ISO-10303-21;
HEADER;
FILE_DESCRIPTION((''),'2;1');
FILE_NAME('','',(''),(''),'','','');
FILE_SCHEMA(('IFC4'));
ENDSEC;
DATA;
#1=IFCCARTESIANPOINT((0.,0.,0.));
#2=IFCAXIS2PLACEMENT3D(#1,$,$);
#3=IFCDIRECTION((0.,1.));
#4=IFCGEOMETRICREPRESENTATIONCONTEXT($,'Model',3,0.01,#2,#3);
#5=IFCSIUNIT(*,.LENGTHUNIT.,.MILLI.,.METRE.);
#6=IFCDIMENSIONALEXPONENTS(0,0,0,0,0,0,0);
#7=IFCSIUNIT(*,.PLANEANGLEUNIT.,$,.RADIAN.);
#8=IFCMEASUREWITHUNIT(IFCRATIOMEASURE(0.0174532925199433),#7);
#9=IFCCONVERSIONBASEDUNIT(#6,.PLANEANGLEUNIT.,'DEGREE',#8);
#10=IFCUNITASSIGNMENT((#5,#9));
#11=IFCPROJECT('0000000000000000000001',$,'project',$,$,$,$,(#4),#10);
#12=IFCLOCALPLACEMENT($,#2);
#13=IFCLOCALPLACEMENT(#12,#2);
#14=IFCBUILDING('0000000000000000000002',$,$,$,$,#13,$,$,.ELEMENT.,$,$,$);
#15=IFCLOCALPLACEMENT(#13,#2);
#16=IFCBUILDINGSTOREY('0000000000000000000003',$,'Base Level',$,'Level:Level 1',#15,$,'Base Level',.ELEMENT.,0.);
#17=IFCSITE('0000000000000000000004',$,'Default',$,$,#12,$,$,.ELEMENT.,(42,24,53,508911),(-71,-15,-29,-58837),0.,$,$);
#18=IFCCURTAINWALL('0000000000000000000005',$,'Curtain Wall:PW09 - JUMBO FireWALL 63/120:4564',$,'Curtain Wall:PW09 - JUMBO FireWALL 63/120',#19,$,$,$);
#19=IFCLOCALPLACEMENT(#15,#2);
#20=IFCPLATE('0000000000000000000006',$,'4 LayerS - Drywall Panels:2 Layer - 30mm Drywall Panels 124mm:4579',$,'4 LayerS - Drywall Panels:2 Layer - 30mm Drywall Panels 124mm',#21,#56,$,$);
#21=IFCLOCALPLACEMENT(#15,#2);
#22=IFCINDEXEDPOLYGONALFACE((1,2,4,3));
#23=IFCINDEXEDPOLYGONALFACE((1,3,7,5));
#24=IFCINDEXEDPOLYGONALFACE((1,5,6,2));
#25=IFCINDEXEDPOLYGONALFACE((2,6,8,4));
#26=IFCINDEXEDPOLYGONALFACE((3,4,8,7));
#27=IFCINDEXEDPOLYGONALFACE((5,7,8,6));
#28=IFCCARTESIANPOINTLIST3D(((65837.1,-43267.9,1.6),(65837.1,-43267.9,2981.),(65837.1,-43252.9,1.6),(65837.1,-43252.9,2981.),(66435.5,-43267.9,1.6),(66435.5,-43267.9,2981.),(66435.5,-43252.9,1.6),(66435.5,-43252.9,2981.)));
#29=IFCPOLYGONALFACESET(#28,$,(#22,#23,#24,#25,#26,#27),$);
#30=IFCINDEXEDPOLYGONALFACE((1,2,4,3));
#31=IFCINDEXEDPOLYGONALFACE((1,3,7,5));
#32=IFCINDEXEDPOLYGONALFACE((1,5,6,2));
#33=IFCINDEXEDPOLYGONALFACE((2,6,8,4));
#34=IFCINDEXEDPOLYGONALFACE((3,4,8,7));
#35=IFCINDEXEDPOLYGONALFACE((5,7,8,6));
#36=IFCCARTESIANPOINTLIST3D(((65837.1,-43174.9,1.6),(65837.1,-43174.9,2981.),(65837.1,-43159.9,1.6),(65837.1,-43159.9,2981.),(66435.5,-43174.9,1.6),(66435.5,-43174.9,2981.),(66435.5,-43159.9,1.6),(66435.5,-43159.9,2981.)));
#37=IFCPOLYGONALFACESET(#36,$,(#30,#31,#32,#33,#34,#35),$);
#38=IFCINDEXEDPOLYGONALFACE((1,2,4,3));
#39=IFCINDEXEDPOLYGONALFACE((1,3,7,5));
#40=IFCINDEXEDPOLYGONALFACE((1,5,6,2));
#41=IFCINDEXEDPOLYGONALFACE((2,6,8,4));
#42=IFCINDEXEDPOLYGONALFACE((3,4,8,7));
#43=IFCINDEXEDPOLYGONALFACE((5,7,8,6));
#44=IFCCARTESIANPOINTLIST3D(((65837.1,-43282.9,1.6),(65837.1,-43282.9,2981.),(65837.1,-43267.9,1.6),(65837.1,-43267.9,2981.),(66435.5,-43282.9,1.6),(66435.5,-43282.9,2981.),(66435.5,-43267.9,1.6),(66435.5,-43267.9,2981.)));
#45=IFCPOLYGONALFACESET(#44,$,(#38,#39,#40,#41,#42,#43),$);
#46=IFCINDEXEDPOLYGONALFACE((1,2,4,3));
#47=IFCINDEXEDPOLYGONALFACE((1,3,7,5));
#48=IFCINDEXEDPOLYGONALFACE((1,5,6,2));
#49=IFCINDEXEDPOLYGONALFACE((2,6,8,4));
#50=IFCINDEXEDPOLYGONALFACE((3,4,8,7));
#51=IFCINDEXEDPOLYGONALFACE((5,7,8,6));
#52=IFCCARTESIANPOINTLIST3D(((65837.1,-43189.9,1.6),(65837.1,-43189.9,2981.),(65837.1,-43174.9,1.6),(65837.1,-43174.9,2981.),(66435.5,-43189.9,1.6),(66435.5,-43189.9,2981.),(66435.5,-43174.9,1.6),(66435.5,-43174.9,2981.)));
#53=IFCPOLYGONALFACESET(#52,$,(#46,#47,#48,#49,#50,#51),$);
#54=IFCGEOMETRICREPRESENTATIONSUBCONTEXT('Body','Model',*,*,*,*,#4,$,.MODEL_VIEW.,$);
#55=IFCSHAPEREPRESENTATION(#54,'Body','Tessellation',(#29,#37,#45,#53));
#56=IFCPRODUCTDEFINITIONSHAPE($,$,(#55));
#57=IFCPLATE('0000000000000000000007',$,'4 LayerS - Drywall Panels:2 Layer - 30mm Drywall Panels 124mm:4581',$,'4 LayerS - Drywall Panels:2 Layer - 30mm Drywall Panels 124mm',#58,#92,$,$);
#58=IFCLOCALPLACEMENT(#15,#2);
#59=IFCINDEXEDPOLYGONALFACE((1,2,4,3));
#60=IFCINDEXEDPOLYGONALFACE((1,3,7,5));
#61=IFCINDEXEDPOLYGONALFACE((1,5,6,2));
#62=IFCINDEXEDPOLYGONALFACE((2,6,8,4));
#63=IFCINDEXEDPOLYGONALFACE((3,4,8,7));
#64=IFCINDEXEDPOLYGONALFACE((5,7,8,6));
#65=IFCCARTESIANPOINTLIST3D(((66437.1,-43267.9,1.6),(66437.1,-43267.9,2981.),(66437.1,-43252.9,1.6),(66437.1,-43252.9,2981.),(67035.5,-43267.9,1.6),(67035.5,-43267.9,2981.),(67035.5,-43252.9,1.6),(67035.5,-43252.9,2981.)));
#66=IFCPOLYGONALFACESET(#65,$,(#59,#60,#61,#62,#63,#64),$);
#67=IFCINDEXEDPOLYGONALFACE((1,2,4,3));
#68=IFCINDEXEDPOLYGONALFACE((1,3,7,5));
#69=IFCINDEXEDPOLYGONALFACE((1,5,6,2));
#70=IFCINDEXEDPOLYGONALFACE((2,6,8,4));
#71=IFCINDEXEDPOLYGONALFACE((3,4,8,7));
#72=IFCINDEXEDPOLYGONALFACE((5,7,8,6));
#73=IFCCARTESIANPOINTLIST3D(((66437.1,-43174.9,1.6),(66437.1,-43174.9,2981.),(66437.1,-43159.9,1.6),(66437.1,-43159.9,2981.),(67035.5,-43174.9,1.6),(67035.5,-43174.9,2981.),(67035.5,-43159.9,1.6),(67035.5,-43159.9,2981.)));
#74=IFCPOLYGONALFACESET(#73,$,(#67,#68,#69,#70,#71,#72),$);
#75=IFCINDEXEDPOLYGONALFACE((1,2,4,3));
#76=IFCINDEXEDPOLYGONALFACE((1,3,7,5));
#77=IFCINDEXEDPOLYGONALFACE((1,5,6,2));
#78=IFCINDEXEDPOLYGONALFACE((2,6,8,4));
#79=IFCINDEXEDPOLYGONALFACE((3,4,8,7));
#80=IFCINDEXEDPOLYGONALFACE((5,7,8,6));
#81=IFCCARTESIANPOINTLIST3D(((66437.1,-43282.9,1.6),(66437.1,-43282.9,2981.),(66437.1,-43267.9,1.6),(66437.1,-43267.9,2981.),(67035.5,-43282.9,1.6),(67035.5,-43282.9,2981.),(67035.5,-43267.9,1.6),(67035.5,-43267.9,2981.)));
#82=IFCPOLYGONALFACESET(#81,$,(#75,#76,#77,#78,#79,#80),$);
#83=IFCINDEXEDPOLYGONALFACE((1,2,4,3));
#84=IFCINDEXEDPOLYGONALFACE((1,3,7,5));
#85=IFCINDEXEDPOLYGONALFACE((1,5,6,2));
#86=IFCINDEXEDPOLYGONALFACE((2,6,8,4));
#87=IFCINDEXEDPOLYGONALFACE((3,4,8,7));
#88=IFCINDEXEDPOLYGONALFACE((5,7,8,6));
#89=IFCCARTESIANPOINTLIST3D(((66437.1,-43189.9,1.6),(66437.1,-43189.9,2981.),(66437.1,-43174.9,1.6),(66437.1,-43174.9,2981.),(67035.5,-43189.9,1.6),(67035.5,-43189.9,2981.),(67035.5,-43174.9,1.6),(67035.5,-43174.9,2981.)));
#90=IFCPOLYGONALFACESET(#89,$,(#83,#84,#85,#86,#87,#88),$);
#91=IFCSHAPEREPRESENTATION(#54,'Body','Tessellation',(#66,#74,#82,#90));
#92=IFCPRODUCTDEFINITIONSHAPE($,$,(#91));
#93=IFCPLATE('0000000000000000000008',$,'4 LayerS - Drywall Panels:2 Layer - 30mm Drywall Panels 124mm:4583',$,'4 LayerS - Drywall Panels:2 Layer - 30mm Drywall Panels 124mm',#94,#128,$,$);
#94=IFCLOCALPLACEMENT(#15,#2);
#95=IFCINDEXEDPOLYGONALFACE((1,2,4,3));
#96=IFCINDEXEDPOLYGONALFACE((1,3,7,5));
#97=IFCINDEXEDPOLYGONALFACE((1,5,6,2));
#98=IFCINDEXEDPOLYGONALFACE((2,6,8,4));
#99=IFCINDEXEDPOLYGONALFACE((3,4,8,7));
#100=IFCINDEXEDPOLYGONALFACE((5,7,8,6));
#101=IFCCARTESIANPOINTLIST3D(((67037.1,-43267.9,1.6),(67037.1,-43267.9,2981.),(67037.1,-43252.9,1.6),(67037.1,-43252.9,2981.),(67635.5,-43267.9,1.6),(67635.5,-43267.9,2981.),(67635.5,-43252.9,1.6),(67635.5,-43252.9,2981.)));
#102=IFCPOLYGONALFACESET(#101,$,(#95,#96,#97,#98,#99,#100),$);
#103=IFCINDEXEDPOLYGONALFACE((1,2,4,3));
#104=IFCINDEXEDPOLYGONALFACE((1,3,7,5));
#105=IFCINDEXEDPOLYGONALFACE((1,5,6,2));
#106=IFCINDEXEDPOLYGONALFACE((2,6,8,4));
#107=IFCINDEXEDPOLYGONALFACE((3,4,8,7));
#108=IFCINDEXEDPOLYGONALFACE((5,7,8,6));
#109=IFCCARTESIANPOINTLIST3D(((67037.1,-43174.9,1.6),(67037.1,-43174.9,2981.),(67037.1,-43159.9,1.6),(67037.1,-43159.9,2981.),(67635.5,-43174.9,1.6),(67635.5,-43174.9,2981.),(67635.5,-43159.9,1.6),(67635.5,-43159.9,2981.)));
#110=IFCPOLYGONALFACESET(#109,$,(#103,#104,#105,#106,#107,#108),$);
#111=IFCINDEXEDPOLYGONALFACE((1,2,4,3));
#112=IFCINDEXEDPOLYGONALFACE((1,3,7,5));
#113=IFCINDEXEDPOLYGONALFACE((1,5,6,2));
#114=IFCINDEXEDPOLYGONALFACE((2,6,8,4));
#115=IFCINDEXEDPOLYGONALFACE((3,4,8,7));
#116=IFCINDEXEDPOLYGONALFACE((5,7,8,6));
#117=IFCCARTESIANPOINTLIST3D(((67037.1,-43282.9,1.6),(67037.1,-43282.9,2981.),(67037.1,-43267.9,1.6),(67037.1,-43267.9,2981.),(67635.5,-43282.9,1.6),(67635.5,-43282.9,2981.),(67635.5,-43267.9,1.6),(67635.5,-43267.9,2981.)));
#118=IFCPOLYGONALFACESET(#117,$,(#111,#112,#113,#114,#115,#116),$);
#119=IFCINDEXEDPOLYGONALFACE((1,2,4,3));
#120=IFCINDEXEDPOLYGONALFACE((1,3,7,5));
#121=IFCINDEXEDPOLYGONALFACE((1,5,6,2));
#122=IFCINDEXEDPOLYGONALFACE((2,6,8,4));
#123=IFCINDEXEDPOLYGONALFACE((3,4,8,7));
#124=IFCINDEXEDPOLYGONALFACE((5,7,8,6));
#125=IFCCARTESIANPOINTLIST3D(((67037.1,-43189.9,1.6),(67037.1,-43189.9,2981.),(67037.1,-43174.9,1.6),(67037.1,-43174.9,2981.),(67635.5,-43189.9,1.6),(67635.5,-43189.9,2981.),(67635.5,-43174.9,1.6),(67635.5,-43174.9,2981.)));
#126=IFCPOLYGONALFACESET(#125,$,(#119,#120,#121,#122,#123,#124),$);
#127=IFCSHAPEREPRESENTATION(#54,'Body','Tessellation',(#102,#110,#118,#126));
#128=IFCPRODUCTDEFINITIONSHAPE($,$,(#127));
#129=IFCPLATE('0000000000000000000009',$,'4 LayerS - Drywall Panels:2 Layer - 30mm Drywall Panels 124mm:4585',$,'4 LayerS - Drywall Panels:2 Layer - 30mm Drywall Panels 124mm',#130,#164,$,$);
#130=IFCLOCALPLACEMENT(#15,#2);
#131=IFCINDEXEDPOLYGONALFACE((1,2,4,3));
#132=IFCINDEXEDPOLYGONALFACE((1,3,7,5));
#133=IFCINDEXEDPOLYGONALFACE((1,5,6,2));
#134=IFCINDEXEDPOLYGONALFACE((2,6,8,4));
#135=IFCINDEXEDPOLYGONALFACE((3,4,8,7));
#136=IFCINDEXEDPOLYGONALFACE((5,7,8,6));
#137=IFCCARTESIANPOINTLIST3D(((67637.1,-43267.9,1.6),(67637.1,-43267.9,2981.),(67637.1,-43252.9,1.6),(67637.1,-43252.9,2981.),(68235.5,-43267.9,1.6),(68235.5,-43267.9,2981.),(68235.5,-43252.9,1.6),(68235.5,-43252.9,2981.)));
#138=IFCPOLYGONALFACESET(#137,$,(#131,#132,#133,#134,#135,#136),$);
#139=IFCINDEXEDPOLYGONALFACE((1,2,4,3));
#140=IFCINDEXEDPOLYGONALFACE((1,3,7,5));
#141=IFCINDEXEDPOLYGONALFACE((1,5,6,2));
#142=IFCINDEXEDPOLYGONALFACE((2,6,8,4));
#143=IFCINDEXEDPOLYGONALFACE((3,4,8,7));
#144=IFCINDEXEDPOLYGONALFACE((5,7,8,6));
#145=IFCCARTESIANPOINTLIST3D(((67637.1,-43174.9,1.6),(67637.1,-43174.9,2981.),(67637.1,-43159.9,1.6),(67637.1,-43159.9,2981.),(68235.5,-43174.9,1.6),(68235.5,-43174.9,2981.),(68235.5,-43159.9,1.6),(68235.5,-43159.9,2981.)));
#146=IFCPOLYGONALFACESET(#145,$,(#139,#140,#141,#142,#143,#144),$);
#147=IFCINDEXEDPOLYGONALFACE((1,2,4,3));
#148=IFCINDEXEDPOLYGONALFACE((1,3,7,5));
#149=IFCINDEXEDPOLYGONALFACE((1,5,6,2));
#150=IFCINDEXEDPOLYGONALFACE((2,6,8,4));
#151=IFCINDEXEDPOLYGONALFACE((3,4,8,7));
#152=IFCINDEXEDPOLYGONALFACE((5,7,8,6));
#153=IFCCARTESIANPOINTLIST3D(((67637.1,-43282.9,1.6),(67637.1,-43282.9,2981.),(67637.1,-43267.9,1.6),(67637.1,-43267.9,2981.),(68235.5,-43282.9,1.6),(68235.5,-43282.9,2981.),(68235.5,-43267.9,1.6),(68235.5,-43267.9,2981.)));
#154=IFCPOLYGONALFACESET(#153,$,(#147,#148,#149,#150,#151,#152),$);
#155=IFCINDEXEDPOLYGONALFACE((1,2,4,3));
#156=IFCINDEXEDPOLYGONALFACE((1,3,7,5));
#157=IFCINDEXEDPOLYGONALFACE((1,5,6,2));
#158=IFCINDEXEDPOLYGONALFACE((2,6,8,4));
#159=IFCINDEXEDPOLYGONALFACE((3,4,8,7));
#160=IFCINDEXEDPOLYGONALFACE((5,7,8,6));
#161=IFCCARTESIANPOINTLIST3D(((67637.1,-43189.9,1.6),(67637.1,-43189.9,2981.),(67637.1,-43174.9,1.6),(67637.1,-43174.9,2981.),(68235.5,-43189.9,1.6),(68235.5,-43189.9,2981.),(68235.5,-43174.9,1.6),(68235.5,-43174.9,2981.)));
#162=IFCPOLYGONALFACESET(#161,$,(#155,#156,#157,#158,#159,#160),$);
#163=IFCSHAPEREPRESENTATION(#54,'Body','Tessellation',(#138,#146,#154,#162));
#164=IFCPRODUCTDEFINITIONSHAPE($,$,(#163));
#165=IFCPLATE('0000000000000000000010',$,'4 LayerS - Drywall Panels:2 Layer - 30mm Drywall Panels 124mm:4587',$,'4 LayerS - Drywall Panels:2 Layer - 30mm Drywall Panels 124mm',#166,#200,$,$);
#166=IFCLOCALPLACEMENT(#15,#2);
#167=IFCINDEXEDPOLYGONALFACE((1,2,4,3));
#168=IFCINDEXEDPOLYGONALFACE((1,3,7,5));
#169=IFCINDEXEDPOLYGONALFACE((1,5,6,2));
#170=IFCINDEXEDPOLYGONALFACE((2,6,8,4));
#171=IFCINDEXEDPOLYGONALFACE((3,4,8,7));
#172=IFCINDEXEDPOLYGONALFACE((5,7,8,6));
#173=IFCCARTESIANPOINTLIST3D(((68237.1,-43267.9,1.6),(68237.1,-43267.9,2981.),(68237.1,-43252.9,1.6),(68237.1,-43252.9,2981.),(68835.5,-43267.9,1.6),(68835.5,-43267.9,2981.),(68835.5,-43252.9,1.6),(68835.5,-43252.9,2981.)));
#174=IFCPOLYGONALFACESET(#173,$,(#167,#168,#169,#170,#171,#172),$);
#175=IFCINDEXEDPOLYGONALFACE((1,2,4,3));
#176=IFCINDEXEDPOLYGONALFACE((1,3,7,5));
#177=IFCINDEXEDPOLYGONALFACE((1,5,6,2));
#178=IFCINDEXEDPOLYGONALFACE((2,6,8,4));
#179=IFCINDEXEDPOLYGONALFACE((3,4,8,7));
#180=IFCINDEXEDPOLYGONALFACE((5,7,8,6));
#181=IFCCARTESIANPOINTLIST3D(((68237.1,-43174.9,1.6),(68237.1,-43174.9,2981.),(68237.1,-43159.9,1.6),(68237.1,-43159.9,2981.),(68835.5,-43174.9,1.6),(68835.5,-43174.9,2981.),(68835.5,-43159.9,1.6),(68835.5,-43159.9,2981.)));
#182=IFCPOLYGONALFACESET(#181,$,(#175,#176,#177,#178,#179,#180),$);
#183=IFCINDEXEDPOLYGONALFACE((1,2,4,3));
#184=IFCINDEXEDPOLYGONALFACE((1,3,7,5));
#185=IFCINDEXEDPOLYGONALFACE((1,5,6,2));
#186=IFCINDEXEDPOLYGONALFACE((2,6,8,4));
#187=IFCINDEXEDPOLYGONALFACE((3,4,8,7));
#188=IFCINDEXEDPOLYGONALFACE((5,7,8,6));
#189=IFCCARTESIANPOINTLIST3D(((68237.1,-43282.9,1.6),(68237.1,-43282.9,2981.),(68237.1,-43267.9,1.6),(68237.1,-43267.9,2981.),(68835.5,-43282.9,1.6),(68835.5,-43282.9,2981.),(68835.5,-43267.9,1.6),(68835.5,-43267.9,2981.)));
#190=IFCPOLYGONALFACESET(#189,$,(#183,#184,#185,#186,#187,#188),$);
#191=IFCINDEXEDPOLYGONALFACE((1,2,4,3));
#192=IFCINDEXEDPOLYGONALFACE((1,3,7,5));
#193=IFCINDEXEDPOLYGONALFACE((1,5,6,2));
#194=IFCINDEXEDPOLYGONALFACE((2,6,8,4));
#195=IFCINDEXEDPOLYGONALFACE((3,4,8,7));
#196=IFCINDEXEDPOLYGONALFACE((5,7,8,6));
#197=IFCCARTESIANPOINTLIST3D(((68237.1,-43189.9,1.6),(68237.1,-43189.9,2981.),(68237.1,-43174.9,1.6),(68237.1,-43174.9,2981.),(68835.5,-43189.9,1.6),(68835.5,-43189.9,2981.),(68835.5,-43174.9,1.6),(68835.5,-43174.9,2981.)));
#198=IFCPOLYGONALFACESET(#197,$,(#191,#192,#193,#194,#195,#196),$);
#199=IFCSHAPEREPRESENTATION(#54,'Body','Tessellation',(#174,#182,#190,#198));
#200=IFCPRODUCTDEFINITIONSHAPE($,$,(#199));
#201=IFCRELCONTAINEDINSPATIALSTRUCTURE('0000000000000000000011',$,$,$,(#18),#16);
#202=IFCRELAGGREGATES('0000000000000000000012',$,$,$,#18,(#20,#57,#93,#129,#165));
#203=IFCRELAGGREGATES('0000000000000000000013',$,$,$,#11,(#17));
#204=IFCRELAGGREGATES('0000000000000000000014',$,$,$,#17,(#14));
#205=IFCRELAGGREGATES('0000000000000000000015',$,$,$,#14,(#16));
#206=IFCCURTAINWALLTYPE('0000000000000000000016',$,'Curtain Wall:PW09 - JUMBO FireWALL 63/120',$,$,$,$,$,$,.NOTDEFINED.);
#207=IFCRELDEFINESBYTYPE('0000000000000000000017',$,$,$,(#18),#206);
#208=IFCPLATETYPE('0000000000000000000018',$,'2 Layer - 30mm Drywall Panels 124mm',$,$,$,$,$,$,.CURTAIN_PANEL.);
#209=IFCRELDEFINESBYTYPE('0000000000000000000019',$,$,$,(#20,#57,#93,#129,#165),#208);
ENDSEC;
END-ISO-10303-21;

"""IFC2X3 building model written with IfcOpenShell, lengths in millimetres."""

from ifc_helpers import new_model, entity, si_unit, converted_unit, direction, frame, frame_2d, origin, origin_2d_with_axis, place, context, subcontext, project, spatial, rectangle, extrude, source, transform, mapped, type_object, type_shapes, element, aggregate, save


model = new_model("IFC2X3")

# Units and contexts
model_context = context("Model", 3, precision=0.01, world=origin(), true_north=direction((0.0, 1.0)))
body_context = subcontext(model_context, "Body", "Model", "MODEL_VIEW")
ifc_project = project(units=[si_unit("LENGTHUNIT", "METRE", prefix="MILLI"), converted_unit("PLANEANGLEUNIT", "DEGREE", entity("IfcRatioMeasure", 0.0174532925199433), si_unit("PLANEANGLEUNIT", "RADIAN"), dimensions=[0, 0, 0, 0, 0, 0, 0])], contexts=[model_context])

# Site, building, storey
site_placement = place(None, origin())
site = spatial("IfcSite", under=ifc_project, at=site_placement, Name="Default", CompositionType="ELEMENT", RefLatitude=(42, 24, 53, 508911), RefLongitude=(-71, -15, -29, -58837), RefElevation=0.0)
building_placement = place(site_placement, origin())
building = spatial("IfcBuilding", under=site, at=building_placement, CompositionType="ELEMENT")
storey_placement = place(building_placement, origin())
storey = spatial("IfcBuildingStorey", under=building, at=storey_placement, Name="Base Level", ObjectType="Level:Level 1", LongName="Base Level", CompositionType="ELEMENT", Elevation=0.0)

# Curtain wall, plates
curtain_wall_type = type_object("IfcCurtainWallType", Name="Curtain Wall:PW09 - JUMBO FireWALL 63/120", PredefinedType="NOTDEFINED")
curtain_wall_placement = place(building_placement, origin())
curtain_wall = element("IfcCurtainWall", 1, at=curtain_wall_placement, inside=storey, type_object=curtain_wall_type, Name="Curtain Wall:PW09 - JUMBO FireWALL 63/120:4564", ObjectType="Curtain Wall:PW09 - JUMBO FireWALL 63/120")
plate_type = type_object("IfcPlateType", Name="2 Layer - 30mm Drywall Panels 124mm", PredefinedType="CURTAIN_PANEL")
shared_shape_1 = source(origin(), body_context, "Body", "SweptSolid", [
    extrude(rectangle(XDim=15.0, YDim=598.4, at=origin_2d_with_axis()), frame((0.0, -39.0, 0.0), z_axis=(0.0, 0.0, 1.0), x_axis=(0.0, 1.0, 0.0)), (0.0, 0.0, 1.0), 2979.4),
    extrude(rectangle(XDim=15.0, YDim=598.4, at=origin_2d_with_axis()), frame((0.0, 54.0, 0.0), z_axis=(0.0, 0.0, 1.0), x_axis=(0.0, 1.0, 0.0)), (0.0, 0.0, 1.0), 2979.4),
    extrude(rectangle(XDim=598.4, YDim=15.0, at=frame_2d((0.0, 0.0), x_axis=(1.0, 0.0))), frame((0.0, -54.0, 0.0), z_axis=(0.0, 0.0, 1.0), x_axis=(-1.0, 0.0, 0.0)), (0.0, 0.0, 1.0), 2979.4),
    extrude(rectangle(XDim=15.0, YDim=598.4, at=frame_2d((0.0, 0.0), x_axis=(1.0, 0.0))), frame((0.0, 39.0, 0.0), z_axis=(0.0, 0.0, 1.0), x_axis=(0.0, 1.0, 0.0)), (0.0, 0.0, 1.0), 2979.4),
])
type_shapes(plate_type, [shared_shape_1])
plate_1_placement = place(curtain_wall_placement, frame((66136.3, -43221.4, 1.6)))
plate_1 = element("IfcPlate", 2, at=plate_1_placement, type_object=plate_type, Name="4 LayerS - Drywall Panels:2 Layer - 30mm Drywall Panels 124mm:4579", ObjectType="4 LayerS - Drywall Panels:2 Layer - 30mm Drywall Panels 124mm", context=body_context, shape_type="MappedRepresentation", body=[
    mapped(shared_shape_1, transform((0.0, 0.0, 0.0), scale=1.0)),
])
plate_2_placement = place(curtain_wall_placement, frame((66736.3, -43221.4, 1.6)))
plate_2 = element("IfcPlate", 3, at=plate_2_placement, type_object=plate_type, Name="4 LayerS - Drywall Panels:2 Layer - 30mm Drywall Panels 124mm:4581", ObjectType="4 LayerS - Drywall Panels:2 Layer - 30mm Drywall Panels 124mm", context=body_context, shape_type="MappedRepresentation", body=[
    mapped(shared_shape_1, transform((0.0, 0.0, 0.0), scale=1.0)),
])
plate_3_placement = place(curtain_wall_placement, frame((67336.3, -43221.4, 1.6)))
plate_3 = element("IfcPlate", 4, at=plate_3_placement, type_object=plate_type, Name="4 LayerS - Drywall Panels:2 Layer - 30mm Drywall Panels 124mm:4583", ObjectType="4 LayerS - Drywall Panels:2 Layer - 30mm Drywall Panels 124mm", context=body_context, shape_type="MappedRepresentation", body=[
    mapped(shared_shape_1, transform((0.0, 0.0, 0.0), scale=1.0)),
])
plate_4_placement = place(curtain_wall_placement, frame((67936.3, -43221.4, 1.6)))
plate_4 = element("IfcPlate", 5, at=plate_4_placement, type_object=plate_type, Name="4 LayerS - Drywall Panels:2 Layer - 30mm Drywall Panels 124mm:4585", ObjectType="4 LayerS - Drywall Panels:2 Layer - 30mm Drywall Panels 124mm", context=body_context, shape_type="MappedRepresentation", body=[
    mapped(shared_shape_1, transform((0.0, 0.0, 0.0), scale=1.0)),
])
plate_5_placement = place(curtain_wall_placement, frame((68536.3, -43221.4, 1.6)))
plate_5 = element("IfcPlate", 6, at=plate_5_placement, type_object=plate_type, Name="4 LayerS - Drywall Panels:2 Layer - 30mm Drywall Panels 124mm:4587", ObjectType="4 LayerS - Drywall Panels:2 Layer - 30mm Drywall Panels 124mm", context=body_context, shape_type="MappedRepresentation", body=[
    mapped(shared_shape_1, transform((0.0, 0.0, 0.0), scale=1.0)),
])
aggregate(curtain_wall, [plate_1, plate_2, plate_3, plate_4, plate_5])

save(model, "model.ifc")
